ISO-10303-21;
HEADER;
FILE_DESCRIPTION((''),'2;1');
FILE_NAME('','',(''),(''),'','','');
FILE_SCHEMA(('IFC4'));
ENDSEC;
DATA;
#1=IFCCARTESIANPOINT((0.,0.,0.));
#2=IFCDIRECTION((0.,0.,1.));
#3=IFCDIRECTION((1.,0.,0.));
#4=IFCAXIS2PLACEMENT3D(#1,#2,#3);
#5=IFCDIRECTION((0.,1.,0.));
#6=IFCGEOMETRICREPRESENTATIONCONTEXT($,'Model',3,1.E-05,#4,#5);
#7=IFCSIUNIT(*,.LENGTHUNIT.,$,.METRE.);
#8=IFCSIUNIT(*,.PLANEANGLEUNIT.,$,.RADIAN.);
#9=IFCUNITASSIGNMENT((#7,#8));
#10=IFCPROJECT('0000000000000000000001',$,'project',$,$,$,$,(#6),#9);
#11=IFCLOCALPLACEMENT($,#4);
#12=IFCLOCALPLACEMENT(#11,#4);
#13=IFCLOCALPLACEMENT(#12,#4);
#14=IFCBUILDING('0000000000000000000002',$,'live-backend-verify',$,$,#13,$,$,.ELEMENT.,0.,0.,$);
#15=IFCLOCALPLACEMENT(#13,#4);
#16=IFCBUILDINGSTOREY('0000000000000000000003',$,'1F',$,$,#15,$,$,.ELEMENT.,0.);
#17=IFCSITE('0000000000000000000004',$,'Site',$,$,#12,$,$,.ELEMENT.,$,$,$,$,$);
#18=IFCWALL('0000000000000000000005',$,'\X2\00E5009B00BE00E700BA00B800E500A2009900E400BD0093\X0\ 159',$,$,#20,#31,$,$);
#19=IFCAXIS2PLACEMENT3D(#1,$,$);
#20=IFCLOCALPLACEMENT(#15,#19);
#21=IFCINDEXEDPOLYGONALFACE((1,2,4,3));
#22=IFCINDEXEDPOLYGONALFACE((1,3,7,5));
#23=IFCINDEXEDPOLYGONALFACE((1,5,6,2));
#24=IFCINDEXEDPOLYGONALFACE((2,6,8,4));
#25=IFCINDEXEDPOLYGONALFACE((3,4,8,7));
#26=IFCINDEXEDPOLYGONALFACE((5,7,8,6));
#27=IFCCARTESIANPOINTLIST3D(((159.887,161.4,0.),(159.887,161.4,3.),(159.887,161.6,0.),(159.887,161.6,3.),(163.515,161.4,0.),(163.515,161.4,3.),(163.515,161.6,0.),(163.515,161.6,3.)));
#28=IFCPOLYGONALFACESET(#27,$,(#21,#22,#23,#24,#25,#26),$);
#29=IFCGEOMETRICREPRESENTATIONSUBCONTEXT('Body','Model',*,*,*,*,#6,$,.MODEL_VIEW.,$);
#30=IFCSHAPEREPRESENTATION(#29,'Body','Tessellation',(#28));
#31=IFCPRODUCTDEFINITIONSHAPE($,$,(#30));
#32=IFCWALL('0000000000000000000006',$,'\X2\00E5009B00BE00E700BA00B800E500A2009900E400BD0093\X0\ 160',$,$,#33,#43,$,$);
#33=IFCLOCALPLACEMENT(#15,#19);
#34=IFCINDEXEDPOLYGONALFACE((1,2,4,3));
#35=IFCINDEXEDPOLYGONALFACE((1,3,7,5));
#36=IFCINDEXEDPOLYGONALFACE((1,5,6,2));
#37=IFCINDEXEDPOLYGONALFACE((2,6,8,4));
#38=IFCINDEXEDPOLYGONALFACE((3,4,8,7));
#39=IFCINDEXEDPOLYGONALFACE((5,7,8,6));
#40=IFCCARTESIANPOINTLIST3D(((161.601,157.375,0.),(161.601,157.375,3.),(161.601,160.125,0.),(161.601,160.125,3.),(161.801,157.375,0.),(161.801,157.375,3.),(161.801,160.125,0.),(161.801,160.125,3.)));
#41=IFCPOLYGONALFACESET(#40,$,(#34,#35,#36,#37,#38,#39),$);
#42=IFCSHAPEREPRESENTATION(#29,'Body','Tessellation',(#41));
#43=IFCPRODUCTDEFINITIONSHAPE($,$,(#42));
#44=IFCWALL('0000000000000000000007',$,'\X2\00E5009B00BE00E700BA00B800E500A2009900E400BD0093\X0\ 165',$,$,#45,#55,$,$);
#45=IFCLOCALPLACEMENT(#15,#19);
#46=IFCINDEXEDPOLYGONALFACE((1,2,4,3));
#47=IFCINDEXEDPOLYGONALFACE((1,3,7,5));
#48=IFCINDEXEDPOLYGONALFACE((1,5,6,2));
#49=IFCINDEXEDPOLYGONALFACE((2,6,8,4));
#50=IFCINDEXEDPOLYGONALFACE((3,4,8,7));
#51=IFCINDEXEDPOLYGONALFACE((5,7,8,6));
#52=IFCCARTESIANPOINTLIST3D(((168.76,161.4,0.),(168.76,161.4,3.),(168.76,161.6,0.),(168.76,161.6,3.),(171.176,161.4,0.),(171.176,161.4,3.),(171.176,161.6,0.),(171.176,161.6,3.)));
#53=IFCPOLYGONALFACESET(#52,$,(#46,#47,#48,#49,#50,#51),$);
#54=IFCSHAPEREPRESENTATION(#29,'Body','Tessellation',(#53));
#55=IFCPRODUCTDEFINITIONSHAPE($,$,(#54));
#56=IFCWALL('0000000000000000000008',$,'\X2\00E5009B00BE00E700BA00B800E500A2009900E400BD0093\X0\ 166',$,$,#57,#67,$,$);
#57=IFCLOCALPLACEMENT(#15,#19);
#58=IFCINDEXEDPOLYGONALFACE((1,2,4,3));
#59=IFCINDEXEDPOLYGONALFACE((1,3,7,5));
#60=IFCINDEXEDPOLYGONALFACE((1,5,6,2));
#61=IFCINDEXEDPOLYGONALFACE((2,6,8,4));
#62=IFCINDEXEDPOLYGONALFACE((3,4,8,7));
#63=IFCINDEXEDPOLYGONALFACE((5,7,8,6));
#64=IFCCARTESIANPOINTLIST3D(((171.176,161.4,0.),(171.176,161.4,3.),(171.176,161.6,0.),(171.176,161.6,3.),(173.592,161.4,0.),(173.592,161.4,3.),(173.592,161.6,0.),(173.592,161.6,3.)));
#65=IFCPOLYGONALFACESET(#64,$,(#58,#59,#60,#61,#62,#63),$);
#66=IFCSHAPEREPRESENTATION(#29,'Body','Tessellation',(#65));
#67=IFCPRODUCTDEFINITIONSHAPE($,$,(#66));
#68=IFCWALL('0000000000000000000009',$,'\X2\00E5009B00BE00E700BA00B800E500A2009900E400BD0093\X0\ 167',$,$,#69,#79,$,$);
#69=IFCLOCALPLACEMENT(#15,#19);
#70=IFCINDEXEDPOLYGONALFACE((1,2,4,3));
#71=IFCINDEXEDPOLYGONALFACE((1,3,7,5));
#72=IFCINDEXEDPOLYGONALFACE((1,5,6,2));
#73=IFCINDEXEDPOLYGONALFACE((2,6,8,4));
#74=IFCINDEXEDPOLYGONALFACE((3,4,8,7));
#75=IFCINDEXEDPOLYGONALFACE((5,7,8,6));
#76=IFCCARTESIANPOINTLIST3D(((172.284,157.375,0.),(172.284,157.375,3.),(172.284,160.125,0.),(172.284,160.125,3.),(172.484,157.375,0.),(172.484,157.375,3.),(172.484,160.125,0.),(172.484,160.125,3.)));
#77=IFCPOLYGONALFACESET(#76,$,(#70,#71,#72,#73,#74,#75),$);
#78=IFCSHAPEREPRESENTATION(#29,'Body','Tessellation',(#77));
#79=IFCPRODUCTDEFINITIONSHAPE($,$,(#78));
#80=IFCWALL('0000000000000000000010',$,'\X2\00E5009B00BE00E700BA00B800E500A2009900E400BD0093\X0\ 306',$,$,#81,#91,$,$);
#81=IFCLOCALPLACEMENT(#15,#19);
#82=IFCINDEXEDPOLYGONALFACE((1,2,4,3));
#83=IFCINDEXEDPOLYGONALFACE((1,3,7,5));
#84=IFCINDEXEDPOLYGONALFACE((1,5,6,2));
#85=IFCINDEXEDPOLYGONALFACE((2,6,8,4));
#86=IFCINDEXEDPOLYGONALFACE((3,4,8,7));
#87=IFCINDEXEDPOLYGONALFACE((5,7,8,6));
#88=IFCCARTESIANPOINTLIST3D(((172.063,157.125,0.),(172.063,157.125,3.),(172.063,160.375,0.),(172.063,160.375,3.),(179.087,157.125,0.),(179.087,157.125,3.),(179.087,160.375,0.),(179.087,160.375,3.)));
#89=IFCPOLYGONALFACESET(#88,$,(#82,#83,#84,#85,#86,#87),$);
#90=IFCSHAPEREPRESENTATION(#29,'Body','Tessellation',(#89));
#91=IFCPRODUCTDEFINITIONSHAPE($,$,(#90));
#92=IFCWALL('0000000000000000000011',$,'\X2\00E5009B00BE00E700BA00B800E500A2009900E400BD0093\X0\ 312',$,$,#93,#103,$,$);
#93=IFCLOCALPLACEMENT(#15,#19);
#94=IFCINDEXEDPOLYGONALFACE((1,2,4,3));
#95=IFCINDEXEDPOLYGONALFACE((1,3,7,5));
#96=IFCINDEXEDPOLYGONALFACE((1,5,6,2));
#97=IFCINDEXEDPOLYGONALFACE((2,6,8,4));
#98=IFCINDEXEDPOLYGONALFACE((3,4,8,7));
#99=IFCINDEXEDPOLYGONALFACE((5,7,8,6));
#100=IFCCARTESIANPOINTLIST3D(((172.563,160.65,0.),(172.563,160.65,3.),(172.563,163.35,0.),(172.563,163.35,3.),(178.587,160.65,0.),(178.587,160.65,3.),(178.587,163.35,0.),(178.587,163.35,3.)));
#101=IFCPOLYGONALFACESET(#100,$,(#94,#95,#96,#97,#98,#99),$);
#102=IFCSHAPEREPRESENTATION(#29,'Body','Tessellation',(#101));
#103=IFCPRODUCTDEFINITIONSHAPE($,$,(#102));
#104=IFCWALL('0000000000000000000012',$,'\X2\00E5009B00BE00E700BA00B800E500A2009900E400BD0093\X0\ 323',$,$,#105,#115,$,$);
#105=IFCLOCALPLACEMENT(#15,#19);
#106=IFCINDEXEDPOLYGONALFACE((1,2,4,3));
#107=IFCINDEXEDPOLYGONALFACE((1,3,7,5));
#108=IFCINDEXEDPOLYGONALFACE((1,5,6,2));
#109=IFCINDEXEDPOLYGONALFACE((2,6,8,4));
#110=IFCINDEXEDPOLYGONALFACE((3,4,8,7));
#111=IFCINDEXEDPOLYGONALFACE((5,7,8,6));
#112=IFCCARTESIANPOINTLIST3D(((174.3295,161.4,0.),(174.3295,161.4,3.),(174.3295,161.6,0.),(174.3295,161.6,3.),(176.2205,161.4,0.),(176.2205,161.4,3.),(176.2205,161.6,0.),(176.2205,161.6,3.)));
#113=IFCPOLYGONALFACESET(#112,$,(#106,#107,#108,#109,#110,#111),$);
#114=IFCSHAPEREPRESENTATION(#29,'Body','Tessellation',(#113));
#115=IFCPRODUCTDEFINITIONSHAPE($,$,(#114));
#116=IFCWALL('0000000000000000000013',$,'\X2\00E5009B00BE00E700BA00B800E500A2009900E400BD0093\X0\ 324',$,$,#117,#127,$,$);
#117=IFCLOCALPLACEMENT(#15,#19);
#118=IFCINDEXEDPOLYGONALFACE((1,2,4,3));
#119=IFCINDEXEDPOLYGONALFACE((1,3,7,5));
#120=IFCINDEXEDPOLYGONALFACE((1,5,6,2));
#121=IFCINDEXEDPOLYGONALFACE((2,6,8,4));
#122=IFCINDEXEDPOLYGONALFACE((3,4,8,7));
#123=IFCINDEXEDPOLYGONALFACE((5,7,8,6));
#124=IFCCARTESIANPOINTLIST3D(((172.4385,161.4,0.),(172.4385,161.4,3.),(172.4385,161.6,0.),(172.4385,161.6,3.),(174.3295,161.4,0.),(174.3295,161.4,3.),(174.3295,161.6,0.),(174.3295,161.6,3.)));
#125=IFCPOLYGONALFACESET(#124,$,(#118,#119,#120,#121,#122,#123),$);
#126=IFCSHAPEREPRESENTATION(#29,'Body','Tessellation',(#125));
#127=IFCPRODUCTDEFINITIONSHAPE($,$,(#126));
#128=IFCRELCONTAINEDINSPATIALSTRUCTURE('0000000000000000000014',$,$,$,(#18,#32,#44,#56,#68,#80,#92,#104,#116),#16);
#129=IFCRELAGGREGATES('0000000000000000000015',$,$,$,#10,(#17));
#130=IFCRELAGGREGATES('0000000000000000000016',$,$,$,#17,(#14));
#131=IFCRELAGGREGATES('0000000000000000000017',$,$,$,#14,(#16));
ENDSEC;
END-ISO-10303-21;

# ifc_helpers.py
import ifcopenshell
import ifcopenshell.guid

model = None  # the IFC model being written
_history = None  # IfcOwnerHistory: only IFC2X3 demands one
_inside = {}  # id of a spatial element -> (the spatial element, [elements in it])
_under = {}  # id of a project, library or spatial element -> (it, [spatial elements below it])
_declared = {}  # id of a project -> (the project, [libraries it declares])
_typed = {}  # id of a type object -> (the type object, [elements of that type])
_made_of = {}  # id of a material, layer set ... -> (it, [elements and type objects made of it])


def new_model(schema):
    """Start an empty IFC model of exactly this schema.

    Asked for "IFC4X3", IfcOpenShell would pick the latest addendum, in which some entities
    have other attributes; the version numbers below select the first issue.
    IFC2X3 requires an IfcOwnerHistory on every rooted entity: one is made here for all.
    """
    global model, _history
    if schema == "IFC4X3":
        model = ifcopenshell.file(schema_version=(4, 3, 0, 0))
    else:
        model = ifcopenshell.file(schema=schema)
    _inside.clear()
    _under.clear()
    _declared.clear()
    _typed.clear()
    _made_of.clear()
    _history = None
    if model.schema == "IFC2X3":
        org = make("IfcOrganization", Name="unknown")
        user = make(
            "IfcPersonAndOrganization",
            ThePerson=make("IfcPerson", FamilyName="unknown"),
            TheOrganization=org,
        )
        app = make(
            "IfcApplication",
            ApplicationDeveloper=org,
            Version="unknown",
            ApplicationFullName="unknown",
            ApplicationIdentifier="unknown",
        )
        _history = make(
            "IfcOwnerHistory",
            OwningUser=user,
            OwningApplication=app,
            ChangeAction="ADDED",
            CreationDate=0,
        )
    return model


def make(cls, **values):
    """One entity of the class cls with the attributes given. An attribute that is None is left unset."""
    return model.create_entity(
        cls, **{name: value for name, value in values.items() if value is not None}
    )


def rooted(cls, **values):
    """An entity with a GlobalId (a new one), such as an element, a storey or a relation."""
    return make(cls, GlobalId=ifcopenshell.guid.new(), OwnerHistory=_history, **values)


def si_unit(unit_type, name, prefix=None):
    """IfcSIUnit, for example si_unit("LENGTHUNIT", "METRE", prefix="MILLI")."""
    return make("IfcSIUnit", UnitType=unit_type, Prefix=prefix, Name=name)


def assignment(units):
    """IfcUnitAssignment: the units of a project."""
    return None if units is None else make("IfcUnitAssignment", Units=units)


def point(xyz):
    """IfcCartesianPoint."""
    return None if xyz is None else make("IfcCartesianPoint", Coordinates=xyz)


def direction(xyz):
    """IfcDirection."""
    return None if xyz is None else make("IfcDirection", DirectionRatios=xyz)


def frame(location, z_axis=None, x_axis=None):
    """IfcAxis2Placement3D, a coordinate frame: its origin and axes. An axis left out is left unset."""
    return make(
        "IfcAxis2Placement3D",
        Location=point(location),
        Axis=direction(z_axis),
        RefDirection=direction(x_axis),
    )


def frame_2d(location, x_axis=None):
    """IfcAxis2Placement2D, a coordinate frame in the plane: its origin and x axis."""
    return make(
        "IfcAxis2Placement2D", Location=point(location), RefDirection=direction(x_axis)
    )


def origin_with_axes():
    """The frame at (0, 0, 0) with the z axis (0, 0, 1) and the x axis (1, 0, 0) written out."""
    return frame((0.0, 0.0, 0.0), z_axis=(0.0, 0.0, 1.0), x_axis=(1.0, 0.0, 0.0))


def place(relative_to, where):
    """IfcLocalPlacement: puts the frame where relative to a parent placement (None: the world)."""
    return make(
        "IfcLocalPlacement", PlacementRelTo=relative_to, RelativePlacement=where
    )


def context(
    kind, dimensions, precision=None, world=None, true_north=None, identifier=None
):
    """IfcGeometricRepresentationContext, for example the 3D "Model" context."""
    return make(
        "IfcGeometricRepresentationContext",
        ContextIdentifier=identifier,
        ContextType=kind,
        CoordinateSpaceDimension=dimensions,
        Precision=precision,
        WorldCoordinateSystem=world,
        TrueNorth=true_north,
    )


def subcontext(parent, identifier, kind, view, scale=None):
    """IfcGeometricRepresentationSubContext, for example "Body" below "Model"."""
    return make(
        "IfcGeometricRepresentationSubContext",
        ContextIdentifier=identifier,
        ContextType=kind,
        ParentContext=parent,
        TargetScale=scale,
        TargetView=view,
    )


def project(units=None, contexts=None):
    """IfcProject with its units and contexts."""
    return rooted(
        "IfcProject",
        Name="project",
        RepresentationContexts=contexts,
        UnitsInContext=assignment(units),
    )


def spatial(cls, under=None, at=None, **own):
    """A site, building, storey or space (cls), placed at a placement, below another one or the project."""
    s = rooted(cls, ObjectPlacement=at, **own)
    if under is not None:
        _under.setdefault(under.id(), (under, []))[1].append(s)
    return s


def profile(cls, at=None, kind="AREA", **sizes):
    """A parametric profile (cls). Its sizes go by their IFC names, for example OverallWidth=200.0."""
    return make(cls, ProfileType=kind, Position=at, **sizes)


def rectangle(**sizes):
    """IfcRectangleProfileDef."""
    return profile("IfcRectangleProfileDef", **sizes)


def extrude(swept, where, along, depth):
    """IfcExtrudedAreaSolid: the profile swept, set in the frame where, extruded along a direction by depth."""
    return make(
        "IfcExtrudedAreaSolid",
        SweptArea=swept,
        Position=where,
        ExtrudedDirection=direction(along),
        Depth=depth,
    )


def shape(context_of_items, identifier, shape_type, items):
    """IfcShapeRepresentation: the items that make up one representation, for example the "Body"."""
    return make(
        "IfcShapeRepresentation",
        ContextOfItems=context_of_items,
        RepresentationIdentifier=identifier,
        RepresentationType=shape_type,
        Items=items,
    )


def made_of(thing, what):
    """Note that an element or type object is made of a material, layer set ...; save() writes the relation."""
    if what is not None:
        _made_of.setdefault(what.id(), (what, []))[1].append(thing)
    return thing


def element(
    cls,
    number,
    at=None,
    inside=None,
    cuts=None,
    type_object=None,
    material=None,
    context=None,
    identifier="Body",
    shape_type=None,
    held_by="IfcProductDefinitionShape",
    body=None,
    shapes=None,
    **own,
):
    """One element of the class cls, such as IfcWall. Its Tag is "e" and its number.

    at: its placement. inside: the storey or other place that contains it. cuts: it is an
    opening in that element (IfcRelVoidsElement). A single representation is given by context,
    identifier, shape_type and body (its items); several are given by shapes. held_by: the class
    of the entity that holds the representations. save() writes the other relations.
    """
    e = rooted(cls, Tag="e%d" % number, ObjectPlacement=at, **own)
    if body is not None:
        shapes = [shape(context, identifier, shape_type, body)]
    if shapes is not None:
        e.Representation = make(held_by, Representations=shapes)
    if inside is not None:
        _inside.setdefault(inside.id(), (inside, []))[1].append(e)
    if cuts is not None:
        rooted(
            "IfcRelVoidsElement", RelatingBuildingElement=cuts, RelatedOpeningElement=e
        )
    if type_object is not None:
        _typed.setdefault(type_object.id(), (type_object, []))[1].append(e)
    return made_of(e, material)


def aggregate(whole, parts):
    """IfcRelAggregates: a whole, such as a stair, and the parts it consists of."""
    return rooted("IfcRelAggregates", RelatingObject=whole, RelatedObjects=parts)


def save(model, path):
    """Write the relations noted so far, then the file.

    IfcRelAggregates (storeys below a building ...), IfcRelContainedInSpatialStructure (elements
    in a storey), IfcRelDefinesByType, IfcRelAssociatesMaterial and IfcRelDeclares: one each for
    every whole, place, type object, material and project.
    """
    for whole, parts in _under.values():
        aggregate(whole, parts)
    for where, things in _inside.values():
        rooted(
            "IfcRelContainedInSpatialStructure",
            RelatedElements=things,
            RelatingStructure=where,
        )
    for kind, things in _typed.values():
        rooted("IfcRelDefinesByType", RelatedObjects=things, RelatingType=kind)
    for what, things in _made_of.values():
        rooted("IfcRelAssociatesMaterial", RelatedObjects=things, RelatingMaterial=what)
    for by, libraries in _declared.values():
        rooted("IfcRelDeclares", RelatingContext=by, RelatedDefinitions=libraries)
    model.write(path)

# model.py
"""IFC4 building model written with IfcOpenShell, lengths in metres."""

from ifc_helpers import new_model, si_unit, direction, frame, frame_2d, origin_with_axes, place, context, subcontext, project, spatial, rectangle, extrude, element, save


model = new_model("IFC4")

# Units and contexts
model_context = context("Model", 3, precision=1e-05, world=origin_with_axes(), true_north=direction((0.0, 1.0, 0.0)))
body_context = subcontext(model_context, "Body", "Model", "MODEL_VIEW")
ifc_project = project(units=[si_unit("LENGTHUNIT", "METRE"), si_unit("PLANEANGLEUNIT", "RADIAN")], contexts=[model_context])

# Site, building, storey
placement = place(None, origin_with_axes())
site_placement = place(placement, origin_with_axes())
site = spatial("IfcSite", under=ifc_project, at=site_placement, Name="Site", CompositionType="ELEMENT")
building_placement = place(site_placement, origin_with_axes())
building = spatial("IfcBuilding", under=site, at=building_placement, Name="live-backend-verify", CompositionType="ELEMENT", ElevationOfRefHeight=0.0, ElevationOfTerrain=0.0)
storey_placement = place(building_placement, origin_with_axes())
storey = spatial("IfcBuildingStorey", under=building, at=storey_placement, Name="1F", CompositionType="ELEMENT", Elevation=0.0)

# Walls
wall_1_placement = place(storey_placement, frame((161.701, 161.5, 0.0), z_axis=(0.0, 0.0, 1.0), x_axis=(1.0, 0.0, 0.0)))
element("IfcWall", 1, at=wall_1_placement, inside=storey, Name="å\u009b¾çº¸å¢\u0099ä½\u0093 159", context=body_context, shape_type="SweptSolid", body=[
    extrude(rectangle(XDim=3.628, YDim=0.2, at=frame_2d((0.0, 0.0), x_axis=(1.0, 0.0, 0.0))), frame((0.0, 0.0, 0.0), z_axis=(0.0, 0.0, 1.0)), (0.0, 0.0, 1.0), 3.0),
])
wall_2_placement = place(storey_placement, frame((161.701, 158.75, 0.0), z_axis=(0.0, 0.0, 1.0), x_axis=(0.0, 1.0, 0.0)))
element("IfcWall", 2, at=wall_2_placement, inside=storey, Name="å\u009b¾çº¸å¢\u0099ä½\u0093 160", context=body_context, shape_type="SweptSolid", body=[
    extrude(rectangle(XDim=2.75, YDim=0.2, at=frame_2d((0.0, 0.0), x_axis=(1.0, 0.0, 0.0))), frame((0.0, 0.0, 0.0), z_axis=(0.0, 0.0, 1.0)), (0.0, 0.0, 1.0), 3.0),
])
for number, where, z_axis, x_axis, name in (
    (3, (169.968, 161.5, 0.0), (0.0, 0.0, 1.0), (1.0, 0.0, 0.0), "å\u009b¾çº¸å¢\u0099ä½\u0093 165"),
    (4, (172.384, 161.5, 0.0), (0.0, 0.0, 1.0), (-1.0, 0.0, 0.0), "å\u009b¾çº¸å¢\u0099ä½\u0093 166"),
):
    element("IfcWall", number, at=place(storey_placement, frame(where, z_axis=z_axis, x_axis=x_axis)), inside=storey, Name=name, context=body_context, shape_type="SweptSolid", body=[
        extrude(rectangle(XDim=2.416, YDim=0.2, at=frame_2d((0.0, 0.0), x_axis=(1.0, 0.0, 0.0))), frame((0.0, 0.0, 0.0), z_axis=(0.0, 0.0, 1.0)), (0.0, 0.0, 1.0), 3.0),
    ])
wall_3_placement = place(storey_placement, frame((172.384, 158.75, 0.0), z_axis=(0.0, 0.0, 1.0), x_axis=(0.0, 1.0, 0.0)))
element("IfcWall", 5, at=wall_3_placement, inside=storey, Name="å\u009b¾çº¸å¢\u0099ä½\u0093 167", context=body_context, shape_type="SweptSolid", body=[
    extrude(rectangle(XDim=2.75, YDim=0.2, at=frame_2d((0.0, 0.0), x_axis=(1.0, 0.0, 0.0))), frame((0.0, 0.0, 0.0), z_axis=(0.0, 0.0, 1.0)), (0.0, 0.0, 1.0), 3.0),
])
wall_4_placement = place(storey_placement, frame((175.575, 158.75, 0.0), z_axis=(0.0, 0.0, 1.0), x_axis=(1.0, 0.0, 0.0)))
element("IfcWall", 6, at=wall_4_placement, inside=storey, Name="å\u009b¾çº¸å¢\u0099ä½\u0093 306", context=body_context, shape_type="SweptSolid", body=[
    extrude(rectangle(XDim=7.024, YDim=3.25, at=frame_2d((0.0, 0.0), x_axis=(1.0, 0.0, 0.0))), frame((0.0, 0.0, 0.0), z_axis=(0.0, 0.0, 1.0)), (0.0, 0.0, 1.0), 3.0),
])
wall_5_placement = place(storey_placement, frame((175.575, 162.0, 0.0), z_axis=(0.0, 0.0, 1.0), x_axis=(1.0, 0.0, 0.0)))
element("IfcWall", 7, at=wall_5_placement, inside=storey, Name="å\u009b¾çº¸å¢\u0099ä½\u0093 312", context=body_context, shape_type="SweptSolid", body=[
    extrude(rectangle(XDim=6.024, YDim=2.7, at=frame_2d((0.0, 0.0), x_axis=(1.0, 0.0, 0.0))), frame((0.0, 0.0, 0.0), z_axis=(0.0, 0.0, 1.0)), (0.0, 0.0, 1.0), 3.0),
])
for number, where, z_axis, x_axis, name in (
    (8, (175.275, 161.5, 0.0), (0.0, 0.0, 1.0), (-1.0, 0.0, 0.0), "å\u009b¾çº¸å¢\u0099ä½\u0093 323"),
    (9, (173.384, 161.5, 0.0), (0.0, 0.0, 1.0), (1.0, 0.0, 0.0), "å\u009b¾çº¸å¢\u0099ä½\u0093 324"),
):
    element("IfcWall", number, at=place(storey_placement, frame(where, z_axis=z_axis, x_axis=x_axis)), inside=storey, Name=name, context=body_context, shape_type="SweptSolid", body=[
        extrude(rectangle(XDim=1.891, YDim=0.2, at=frame_2d((0.0, 0.0), x_axis=(1.0, 0.0, 0.0))), frame((0.0, 0.0, 0.0), z_axis=(0.0, 0.0, 1.0)), (0.0, 0.0, 1.0), 3.0),
    ])

save(model, "model.ifc")
